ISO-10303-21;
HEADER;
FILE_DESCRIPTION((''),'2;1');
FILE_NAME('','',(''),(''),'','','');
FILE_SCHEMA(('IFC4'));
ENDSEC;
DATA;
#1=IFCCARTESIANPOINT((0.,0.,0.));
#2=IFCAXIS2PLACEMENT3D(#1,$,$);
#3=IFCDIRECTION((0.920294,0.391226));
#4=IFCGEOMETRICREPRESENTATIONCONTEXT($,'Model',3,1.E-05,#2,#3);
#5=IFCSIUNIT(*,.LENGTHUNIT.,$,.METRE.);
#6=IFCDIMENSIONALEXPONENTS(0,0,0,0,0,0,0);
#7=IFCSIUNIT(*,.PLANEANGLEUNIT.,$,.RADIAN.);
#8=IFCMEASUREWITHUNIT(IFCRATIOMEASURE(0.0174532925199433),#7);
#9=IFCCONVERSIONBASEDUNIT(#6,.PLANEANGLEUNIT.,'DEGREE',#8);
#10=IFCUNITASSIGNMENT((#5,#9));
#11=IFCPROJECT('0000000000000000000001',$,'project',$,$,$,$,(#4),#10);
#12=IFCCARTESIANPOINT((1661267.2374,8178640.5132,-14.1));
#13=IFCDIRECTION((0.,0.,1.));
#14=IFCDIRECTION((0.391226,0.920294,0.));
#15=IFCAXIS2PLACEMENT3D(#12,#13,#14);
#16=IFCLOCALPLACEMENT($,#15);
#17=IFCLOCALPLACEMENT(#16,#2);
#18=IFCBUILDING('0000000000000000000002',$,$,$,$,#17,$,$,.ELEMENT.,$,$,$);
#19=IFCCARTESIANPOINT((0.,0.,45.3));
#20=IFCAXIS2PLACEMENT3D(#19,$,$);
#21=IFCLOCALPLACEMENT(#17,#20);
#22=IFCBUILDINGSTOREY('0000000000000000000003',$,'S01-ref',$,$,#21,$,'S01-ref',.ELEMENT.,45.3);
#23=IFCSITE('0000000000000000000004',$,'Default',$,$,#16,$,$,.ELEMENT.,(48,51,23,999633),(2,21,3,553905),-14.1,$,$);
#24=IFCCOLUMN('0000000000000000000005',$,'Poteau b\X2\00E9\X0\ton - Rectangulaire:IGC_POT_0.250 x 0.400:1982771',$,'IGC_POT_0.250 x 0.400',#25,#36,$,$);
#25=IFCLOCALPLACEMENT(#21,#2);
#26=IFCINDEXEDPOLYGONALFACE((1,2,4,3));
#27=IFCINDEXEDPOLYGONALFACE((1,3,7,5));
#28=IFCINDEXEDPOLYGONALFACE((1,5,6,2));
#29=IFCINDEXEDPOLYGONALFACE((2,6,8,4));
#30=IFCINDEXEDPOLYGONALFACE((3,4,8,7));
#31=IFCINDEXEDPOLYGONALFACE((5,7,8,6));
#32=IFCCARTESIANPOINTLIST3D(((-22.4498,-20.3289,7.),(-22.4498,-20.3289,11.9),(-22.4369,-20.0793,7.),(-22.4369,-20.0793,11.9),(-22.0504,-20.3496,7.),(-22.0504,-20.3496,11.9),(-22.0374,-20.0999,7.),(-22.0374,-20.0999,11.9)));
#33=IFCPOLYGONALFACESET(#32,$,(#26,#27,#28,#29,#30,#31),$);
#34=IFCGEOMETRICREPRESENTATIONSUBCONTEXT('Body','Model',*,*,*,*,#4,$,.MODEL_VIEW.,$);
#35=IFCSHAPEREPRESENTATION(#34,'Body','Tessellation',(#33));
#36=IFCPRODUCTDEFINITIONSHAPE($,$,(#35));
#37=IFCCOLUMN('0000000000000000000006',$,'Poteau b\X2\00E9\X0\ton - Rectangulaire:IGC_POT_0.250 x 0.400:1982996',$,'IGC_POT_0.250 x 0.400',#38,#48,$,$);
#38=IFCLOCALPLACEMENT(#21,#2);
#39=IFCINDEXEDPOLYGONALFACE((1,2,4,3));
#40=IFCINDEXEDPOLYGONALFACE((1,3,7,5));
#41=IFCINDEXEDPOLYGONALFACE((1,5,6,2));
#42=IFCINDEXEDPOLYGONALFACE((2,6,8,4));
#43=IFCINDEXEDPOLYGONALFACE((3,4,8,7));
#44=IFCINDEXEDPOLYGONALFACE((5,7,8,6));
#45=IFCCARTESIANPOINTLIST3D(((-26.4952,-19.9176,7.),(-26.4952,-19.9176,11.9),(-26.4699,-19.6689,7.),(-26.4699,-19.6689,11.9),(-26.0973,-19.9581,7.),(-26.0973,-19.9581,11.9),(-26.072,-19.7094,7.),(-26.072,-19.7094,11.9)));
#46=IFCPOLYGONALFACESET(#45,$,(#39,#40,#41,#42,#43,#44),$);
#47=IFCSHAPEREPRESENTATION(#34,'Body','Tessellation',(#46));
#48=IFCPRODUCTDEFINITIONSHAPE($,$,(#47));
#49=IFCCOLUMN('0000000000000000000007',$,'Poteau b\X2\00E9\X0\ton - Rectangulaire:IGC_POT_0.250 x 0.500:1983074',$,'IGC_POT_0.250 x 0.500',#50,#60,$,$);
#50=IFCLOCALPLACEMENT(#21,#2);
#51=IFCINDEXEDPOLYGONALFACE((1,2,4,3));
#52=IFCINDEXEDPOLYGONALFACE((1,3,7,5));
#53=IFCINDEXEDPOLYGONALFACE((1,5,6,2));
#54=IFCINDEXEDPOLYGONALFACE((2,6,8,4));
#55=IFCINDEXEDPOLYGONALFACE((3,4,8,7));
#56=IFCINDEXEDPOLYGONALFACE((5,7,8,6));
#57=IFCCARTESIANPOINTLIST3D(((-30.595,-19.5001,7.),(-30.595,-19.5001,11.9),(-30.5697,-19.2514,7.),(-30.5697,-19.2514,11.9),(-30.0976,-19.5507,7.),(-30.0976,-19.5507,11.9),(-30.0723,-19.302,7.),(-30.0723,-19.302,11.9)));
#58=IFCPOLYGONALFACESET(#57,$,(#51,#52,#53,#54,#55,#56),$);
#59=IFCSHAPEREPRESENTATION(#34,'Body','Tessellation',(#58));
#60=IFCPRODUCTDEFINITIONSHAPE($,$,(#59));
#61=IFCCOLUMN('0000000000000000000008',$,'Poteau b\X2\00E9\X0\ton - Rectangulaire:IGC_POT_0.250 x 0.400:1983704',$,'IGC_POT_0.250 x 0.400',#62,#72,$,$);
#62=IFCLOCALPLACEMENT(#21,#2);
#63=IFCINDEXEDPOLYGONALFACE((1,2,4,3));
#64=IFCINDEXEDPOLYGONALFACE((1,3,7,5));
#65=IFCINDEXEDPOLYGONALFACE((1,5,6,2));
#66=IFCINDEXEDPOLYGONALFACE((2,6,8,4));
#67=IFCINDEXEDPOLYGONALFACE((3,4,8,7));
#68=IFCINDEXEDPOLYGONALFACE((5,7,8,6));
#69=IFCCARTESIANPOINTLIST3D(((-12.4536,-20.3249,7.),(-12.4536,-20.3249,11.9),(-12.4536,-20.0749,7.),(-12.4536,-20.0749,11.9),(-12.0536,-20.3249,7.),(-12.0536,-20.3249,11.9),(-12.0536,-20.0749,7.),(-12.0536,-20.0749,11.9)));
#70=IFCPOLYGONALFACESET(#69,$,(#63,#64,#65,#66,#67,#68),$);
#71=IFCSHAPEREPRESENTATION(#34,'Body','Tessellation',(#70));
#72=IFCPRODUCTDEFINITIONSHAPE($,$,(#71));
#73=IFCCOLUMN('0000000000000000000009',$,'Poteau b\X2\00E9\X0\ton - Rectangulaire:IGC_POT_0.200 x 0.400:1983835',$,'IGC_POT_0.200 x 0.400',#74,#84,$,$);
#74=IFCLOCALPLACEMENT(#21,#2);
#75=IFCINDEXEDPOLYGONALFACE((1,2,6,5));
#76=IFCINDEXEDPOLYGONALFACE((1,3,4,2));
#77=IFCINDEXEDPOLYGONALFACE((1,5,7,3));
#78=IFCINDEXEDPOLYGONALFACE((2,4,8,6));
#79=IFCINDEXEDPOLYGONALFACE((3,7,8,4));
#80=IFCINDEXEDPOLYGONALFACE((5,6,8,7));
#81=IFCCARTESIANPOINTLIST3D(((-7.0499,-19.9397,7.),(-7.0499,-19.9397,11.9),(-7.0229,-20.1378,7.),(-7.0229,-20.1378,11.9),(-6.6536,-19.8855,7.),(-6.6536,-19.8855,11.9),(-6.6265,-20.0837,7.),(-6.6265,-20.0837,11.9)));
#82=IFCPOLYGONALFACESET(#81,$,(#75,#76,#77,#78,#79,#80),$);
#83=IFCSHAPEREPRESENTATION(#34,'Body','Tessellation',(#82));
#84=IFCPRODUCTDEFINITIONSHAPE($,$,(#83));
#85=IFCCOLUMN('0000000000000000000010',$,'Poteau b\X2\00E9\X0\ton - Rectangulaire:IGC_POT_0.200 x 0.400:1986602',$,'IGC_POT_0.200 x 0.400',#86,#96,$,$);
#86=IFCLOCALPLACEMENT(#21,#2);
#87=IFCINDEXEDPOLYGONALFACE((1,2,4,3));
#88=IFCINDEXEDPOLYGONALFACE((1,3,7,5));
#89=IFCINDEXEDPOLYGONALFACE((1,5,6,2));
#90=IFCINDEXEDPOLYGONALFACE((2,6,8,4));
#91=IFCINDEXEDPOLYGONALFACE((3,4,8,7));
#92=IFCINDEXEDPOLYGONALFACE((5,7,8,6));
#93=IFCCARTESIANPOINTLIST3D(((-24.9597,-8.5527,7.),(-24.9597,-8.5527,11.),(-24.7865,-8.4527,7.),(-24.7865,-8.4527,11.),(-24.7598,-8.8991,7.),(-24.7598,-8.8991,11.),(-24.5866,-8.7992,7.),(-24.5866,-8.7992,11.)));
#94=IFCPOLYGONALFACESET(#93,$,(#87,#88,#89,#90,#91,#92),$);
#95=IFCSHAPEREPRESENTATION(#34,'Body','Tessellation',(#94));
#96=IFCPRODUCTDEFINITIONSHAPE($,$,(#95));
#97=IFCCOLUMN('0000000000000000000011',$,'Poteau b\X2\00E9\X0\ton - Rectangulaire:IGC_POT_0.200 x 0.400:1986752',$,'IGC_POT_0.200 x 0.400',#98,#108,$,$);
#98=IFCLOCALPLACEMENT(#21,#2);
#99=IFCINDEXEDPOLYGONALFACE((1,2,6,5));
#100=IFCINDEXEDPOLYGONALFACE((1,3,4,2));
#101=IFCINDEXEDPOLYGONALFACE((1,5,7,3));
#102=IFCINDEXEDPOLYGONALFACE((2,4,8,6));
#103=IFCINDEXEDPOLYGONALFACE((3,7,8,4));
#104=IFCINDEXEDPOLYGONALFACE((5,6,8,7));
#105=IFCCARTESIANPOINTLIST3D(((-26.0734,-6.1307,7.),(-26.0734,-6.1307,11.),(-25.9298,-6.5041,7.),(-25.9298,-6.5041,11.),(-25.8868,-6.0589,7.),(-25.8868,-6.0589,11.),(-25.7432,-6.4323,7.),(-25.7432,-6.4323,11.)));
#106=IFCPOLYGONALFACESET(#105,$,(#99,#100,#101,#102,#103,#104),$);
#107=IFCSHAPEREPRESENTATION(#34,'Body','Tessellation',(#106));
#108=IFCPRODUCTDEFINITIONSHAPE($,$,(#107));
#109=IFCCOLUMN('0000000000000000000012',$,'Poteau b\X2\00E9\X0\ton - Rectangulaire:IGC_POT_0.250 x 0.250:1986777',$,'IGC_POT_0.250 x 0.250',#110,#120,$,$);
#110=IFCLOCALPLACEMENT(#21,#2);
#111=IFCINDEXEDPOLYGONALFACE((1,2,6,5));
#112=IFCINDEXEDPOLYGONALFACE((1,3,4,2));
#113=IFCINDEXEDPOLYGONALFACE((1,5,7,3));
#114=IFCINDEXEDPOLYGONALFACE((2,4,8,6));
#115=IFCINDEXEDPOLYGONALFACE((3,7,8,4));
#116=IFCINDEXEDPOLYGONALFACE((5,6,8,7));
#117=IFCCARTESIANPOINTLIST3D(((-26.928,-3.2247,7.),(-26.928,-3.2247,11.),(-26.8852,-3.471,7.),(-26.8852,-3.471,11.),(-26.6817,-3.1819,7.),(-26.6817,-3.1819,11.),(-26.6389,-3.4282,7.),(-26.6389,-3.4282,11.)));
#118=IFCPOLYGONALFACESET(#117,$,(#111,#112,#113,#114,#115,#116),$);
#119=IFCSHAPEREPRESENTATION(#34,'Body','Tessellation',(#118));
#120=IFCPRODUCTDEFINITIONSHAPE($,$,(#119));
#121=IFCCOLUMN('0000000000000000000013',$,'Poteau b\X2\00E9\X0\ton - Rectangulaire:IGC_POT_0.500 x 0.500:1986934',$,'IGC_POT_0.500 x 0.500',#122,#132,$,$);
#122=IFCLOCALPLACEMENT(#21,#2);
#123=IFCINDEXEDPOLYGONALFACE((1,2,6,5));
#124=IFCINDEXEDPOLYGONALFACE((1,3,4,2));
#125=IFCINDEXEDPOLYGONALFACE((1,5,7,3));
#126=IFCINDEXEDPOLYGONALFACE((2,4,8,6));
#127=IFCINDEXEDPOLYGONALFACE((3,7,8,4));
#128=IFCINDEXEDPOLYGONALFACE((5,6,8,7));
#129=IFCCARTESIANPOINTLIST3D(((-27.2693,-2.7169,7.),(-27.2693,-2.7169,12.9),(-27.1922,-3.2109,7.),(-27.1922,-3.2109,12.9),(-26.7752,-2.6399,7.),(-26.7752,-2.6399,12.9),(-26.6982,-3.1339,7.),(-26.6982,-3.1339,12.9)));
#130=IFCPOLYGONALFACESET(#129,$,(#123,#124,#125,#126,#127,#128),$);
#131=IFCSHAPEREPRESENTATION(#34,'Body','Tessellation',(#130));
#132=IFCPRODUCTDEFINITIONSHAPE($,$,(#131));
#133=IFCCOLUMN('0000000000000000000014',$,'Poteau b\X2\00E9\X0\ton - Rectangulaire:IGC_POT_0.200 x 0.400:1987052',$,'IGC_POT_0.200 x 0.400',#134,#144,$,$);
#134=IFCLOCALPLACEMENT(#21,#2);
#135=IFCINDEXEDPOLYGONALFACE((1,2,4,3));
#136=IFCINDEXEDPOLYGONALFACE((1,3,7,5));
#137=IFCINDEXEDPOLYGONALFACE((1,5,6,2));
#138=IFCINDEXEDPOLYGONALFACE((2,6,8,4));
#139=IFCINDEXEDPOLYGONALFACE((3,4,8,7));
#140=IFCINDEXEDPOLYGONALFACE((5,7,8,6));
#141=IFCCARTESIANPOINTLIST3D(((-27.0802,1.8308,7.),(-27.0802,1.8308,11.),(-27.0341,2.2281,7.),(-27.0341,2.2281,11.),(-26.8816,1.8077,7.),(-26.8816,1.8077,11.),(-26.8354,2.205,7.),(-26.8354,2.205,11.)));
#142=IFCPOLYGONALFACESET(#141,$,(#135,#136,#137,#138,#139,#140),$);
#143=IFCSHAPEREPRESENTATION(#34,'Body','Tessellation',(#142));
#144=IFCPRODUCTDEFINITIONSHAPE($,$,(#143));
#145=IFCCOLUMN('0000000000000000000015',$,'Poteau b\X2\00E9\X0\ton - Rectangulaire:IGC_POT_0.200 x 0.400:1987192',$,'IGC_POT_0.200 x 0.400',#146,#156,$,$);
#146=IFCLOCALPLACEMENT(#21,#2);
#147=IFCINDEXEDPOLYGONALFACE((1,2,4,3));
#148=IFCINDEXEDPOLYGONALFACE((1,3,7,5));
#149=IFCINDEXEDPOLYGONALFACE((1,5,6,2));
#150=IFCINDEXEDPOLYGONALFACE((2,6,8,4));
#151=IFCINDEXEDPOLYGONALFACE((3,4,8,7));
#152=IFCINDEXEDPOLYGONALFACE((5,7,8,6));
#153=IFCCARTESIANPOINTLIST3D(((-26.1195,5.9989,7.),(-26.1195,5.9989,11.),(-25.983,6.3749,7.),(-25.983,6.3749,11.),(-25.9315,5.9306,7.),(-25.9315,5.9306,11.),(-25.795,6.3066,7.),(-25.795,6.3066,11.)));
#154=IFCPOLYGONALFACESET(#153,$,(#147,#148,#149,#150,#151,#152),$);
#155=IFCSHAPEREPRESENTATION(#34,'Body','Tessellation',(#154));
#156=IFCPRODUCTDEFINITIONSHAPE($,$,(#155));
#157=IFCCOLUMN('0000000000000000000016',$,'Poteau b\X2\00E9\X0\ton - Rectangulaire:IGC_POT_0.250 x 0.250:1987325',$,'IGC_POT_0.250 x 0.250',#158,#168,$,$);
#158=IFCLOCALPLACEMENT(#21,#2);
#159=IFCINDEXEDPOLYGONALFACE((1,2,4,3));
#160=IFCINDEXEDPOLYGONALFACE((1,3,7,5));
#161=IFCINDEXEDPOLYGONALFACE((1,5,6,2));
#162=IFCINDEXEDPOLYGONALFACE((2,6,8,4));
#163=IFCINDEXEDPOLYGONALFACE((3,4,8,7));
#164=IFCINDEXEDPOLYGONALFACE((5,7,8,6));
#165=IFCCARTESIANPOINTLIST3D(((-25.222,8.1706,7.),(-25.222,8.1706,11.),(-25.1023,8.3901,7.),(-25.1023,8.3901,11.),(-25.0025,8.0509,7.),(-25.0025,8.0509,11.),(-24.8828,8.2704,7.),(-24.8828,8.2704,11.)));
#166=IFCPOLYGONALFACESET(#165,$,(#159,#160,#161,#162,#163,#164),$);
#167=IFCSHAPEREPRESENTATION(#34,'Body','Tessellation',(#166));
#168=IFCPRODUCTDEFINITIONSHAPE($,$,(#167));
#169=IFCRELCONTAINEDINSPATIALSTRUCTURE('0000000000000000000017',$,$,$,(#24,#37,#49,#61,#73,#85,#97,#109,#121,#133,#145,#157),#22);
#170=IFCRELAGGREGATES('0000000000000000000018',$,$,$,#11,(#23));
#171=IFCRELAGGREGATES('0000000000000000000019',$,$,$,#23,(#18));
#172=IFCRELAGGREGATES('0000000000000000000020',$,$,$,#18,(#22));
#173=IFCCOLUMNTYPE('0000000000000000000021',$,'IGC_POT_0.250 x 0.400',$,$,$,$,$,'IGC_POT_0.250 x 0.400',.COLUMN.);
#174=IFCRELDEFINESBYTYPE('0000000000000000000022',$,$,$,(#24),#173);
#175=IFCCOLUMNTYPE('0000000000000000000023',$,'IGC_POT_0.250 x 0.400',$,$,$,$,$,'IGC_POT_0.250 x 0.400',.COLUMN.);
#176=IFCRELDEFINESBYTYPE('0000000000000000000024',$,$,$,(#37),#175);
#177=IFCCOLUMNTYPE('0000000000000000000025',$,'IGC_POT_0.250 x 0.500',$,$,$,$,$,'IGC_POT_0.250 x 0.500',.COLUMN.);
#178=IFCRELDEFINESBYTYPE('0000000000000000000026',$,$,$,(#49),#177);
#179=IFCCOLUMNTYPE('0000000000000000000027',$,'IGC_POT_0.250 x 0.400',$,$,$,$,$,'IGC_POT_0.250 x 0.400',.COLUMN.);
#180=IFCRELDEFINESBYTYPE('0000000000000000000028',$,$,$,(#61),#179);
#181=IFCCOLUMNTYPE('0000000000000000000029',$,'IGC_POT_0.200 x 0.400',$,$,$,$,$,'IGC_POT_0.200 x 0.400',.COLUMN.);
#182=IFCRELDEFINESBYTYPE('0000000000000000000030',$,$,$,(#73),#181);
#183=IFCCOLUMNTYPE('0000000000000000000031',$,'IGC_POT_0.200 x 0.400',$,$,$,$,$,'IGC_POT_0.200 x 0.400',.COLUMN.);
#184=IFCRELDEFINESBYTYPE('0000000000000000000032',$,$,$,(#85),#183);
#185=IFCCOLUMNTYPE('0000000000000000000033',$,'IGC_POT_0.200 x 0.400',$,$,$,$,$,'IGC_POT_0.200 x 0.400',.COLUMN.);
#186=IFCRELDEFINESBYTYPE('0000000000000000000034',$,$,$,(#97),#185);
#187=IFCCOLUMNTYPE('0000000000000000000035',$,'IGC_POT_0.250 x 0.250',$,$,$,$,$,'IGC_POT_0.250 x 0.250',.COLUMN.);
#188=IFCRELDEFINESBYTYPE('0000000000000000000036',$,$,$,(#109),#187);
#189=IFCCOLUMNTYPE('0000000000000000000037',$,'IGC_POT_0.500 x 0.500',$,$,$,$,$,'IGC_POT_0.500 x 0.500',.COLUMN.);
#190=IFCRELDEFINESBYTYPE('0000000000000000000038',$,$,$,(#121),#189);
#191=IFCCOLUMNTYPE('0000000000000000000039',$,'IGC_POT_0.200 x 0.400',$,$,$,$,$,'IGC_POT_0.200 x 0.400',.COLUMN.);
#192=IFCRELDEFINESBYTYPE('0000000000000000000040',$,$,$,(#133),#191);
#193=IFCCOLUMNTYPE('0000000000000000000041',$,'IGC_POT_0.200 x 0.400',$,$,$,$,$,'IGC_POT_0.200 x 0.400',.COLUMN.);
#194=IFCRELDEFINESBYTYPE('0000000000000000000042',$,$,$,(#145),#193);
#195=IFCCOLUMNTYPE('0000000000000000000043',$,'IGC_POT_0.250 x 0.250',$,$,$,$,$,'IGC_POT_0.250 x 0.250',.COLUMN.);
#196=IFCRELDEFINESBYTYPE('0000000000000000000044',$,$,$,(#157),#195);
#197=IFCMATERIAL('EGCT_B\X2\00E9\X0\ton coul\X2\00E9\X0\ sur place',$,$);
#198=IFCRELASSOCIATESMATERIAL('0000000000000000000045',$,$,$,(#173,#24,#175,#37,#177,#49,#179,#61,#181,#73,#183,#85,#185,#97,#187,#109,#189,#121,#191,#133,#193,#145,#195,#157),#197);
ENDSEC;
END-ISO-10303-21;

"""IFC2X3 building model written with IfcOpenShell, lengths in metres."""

from ifc_helpers import new_model, entity, si_unit, converted_unit, direction, frame, frame_2d, origin, origin_2d_with_axis, place, context, subcontext, project, spatial, rectangle, extrude, source, transform, mapped, material, type_object, type_shapes, element, save


model = new_model("IFC2X3")

# Units and contexts
model_context = context("Model", 3, precision=1e-05, world=origin(), true_north=direction((0.920294, 0.391226)))
body_context = subcontext(model_context, "Body", "Model", "MODEL_VIEW")
ifc_project = project(units=[si_unit("LENGTHUNIT", "METRE"), converted_unit("PLANEANGLEUNIT", "DEGREE", entity("IfcRatioMeasure", 0.0174532925199433), si_unit("PLANEANGLEUNIT", "RADIAN"), dimensions=[0, 0, 0, 0, 0, 0, 0])], contexts=[model_context])

# Site, building, storey
site_placement = place(None, frame((1661267.2374, 8178640.5132, -14.1), z_axis=(0.0, 0.0, 1.0), x_axis=(0.391226, 0.920294, 0.0)))
site = spatial("IfcSite", under=ifc_project, at=site_placement, Name="Default", CompositionType="ELEMENT", RefLatitude=(48, 51, 23, 999633), RefLongitude=(2, 21, 3, 553905), RefElevation=-14.1)
building_placement = place(site_placement, origin())
building = spatial("IfcBuilding", under=site, at=building_placement, CompositionType="ELEMENT")
storey_placement = place(building_placement, frame((0.0, 0.0, 45.3)))
storey = spatial("IfcBuildingStorey", under=building, at=storey_placement, Name="S01-ref", LongName="S01-ref", CompositionType="ELEMENT", Elevation=45.3)

# Columns
ifc_material = material(Name="EGCT_Béton coulé sur place")
column_type_1 = type_object("IfcColumnType", Name="IGC_POT_0.250 x 0.400", ElementType="IGC_POT_0.250 x 0.400", PredefinedType="COLUMN", material=ifc_material)
shared_shape_1 = source(origin(), body_context, "Body", "SweptSolid", [
    extrude(rectangle(XDim=0.25, YDim=0.4, at=frame_2d((0.0, 0.0), x_axis=(1.0, 0.0))), frame((-22.2436, -20.2144, 52.3), z_axis=(0.0, 0.0, 1.0), x_axis=(0.051722, 0.998662, 0.0)), (0.0, 0.0, 1.0), 4.9),
])
type_shapes(column_type_1, [shared_shape_1])
column_1_placement = place(storey_placement, frame((0.0, 0.0, -45.3)))
element("IfcColumn", 1, at=column_1_placement, inside=storey, type_object=column_type_1, material=ifc_material, Name="Poteau béton - Rectangulaire:IGC_POT_0.250 x 0.400:1982771", ObjectType="IGC_POT_0.250 x 0.400", context=body_context, shape_type="MappedRepresentation", body=[
    mapped(shared_shape_1, transform((0.0, 0.0, 0.0), scale=1.0)),
])
column_type_2 = type_object("IfcColumnType", Name="IGC_POT_0.250 x 0.400", ElementType="IGC_POT_0.250 x 0.400", PredefinedType="COLUMN", material=ifc_material)
shared_shape_2 = source(origin(), body_context, "Body", "SweptSolid", [
    extrude(rectangle(XDim=0.25, YDim=0.4, at=frame_2d((0.0, 0.0), x_axis=(1.0, 0.0))), frame((-26.2836, -19.8135, 52.3), z_axis=(0.0, 0.0, 1.0), x_axis=(0.101222, 0.994864, 0.0)), (0.0, 0.0, 1.0), 4.9),
])
type_shapes(column_type_2, [shared_shape_2])
column_2_placement = place(storey_placement, frame((0.0, 0.0, -45.3)))
element("IfcColumn", 2, at=column_2_placement, inside=storey, type_object=column_type_2, material=ifc_material, Name="Poteau béton - Rectangulaire:IGC_POT_0.250 x 0.400:1982996", ObjectType="IGC_POT_0.250 x 0.400", context=body_context, shape_type="MappedRepresentation", body=[
    mapped(shared_shape_2, transform((0.0, 0.0, 0.0), scale=1.0)),
])
column_type_3 = type_object("IfcColumnType", Name="IGC_POT_0.250 x 0.500", ElementType="IGC_POT_0.250 x 0.500", PredefinedType="COLUMN", material=ifc_material)
shared_shape_3 = source(origin(), body_context, "Body", "SweptSolid", [
    extrude(rectangle(XDim=0.25, YDim=0.5, at=frame_2d((0.0, 0.0), x_axis=(1.0, 0.0))), frame((-30.3336, -19.4011, 52.3), z_axis=(0.0, 0.0, 1.0), x_axis=(0.101222, 0.994864, 0.0)), (0.0, 0.0, 1.0), 4.9),
])
type_shapes(column_type_3, [shared_shape_3])
column_3_placement = place(storey_placement, frame((0.0, 0.0, -45.3)))
element("IfcColumn", 3, at=column_3_placement, inside=storey, type_object=column_type_3, material=ifc_material, Name="Poteau béton - Rectangulaire:IGC_POT_0.250 x 0.500:1983074", ObjectType="IGC_POT_0.250 x 0.500", context=body_context, shape_type="MappedRepresentation", body=[
    mapped(shared_shape_3, transform((0.0, 0.0, 0.0), scale=1.0)),
])
column_type_4 = type_object("IfcColumnType", Name="IGC_POT_0.250 x 0.400", ElementType="IGC_POT_0.250 x 0.400", PredefinedType="COLUMN", material=ifc_material)
shared_shape_4 = source(origin(), body_context, "Body", "SweptSolid", [
    extrude(rectangle(XDim=0.25, YDim=0.4, at=frame_2d((0.0, 0.0), x_axis=(1.0, 0.0))), frame((-12.2536, -20.1999, 52.3), z_axis=(0.0, 0.0, 1.0), x_axis=(0.000003, 1.0, 0.0)), (0.0, 0.0, 1.0), 4.9),
])
type_shapes(column_type_4, [shared_shape_4])
column_4_placement = place(storey_placement, frame((0.0, 0.0, -45.3)))
element("IfcColumn", 4, at=column_4_placement, inside=storey, type_object=column_type_4, material=ifc_material, Name="Poteau béton - Rectangulaire:IGC_POT_0.250 x 0.400:1983704", ObjectType="IGC_POT_0.250 x 0.400", context=body_context, shape_type="MappedRepresentation", body=[
    mapped(shared_shape_4, transform((0.0, 0.0, 0.0), scale=1.0)),
])
column_type_5 = type_object("IfcColumnType", Name="IGC_POT_0.200 x 0.400", ElementType="IGC_POT_0.200 x 0.400", PredefinedType="COLUMN", material=ifc_material)
shared_shape_5 = source(origin(), body_context, "Body", "SweptSolid", [
    extrude(rectangle(XDim=0.2, YDim=0.4, at=frame_2d((0.0, 0.0), x_axis=(1.0, 0.0))), frame((-6.8382, -20.0117, 52.3), z_axis=(0.0, 0.0, 1.0), x_axis=(-0.135411, 0.99079, 0.0)), (0.0, 0.0, 1.0), 4.9),
])
type_shapes(column_type_5, [shared_shape_5])
column_5_placement = place(storey_placement, frame((0.0, 0.0, -45.3)))
element("IfcColumn", 5, at=column_5_placement, inside=storey, type_object=column_type_5, material=ifc_material, Name="Poteau béton - Rectangulaire:IGC_POT_0.200 x 0.400:1983835", ObjectType="IGC_POT_0.200 x 0.400", context=body_context, shape_type="MappedRepresentation", body=[
    mapped(shared_shape_5, transform((0.0, 0.0, 0.0), scale=1.0)),
])
column_type_6 = type_object("IfcColumnType", Name="IGC_POT_0.200 x 0.400", ElementType="IGC_POT_0.200 x 0.400", PredefinedType="COLUMN", material=ifc_material)
shared_shape_6 = source(origin(), body_context, "Body", "SweptSolid", [
    extrude(rectangle(XDim=0.4, YDim=0.2, at=frame_2d((0.0, 0.0), x_axis=(1.0, 0.0))), frame((-24.7732, -8.6759, 52.3), z_axis=(0.0, 0.0, 1.0), x_axis=(-0.499774, 0.866156, 0.0)), (0.0, 0.0, 1.0), 4.0),
])
type_shapes(column_type_6, [shared_shape_6])
column_6_placement = place(storey_placement, frame((0.0, 0.0, -45.3)))
element("IfcColumn", 6, at=column_6_placement, inside=storey, type_object=column_type_6, material=ifc_material, Name="Poteau béton - Rectangulaire:IGC_POT_0.200 x 0.400:1986602", ObjectType="IGC_POT_0.200 x 0.400", context=body_context, shape_type="MappedRepresentation", body=[
    mapped(shared_shape_6, transform((0.0, 0.0, 0.0), scale=1.0)),
])
column_type_7 = type_object("IfcColumnType", Name="IGC_POT_0.200 x 0.400", ElementType="IGC_POT_0.200 x 0.400", PredefinedType="COLUMN", material=ifc_material)
shared_shape_7 = source(origin(), body_context, "Body", "SweptSolid", [
    extrude(rectangle(XDim=0.4, YDim=0.2, at=origin_2d_with_axis()), frame((-25.9083, -6.2815, 52.3), z_axis=(0.0, 0.0, 1.0), x_axis=(-0.358954, 0.933355, 0.0)), (0.0, 0.0, 1.0), 4.0),
])
type_shapes(column_type_7, [shared_shape_7])
column_7_placement = place(storey_placement, frame((0.0, 0.0, -45.3)))
element("IfcColumn", 7, at=column_7_placement, inside=storey, type_object=column_type_7, material=ifc_material, Name="Poteau béton - Rectangulaire:IGC_POT_0.200 x 0.400:1986752", ObjectType="IGC_POT_0.200 x 0.400", context=body_context, shape_type="MappedRepresentation", body=[
    mapped(shared_shape_7, transform((0.0, 0.0, 0.0), scale=1.0)),
])
column_type_8 = type_object("IfcColumnType", Name="IGC_POT_0.250 x 0.250", ElementType="IGC_POT_0.250 x 0.250", PredefinedType="COLUMN", material=ifc_material)
shared_shape_8 = source(origin(), body_context, "Body", "SweptSolid", [
    extrude(rectangle(XDim=0.25, YDim=0.25, at=frame_2d((0.0, 0.0), x_axis=(1.0, 0.0))), frame((-26.7835, -3.3264, 52.3), z_axis=(0.0, 0.0, 1.0), x_axis=(-0.1713, 0.985219, 0.0)), (0.0, 0.0, 1.0), 4.0),
])
type_shapes(column_type_8, [shared_shape_8])
column_8_placement = place(storey_placement, frame((0.0, 0.0, -45.3)))
element("IfcColumn", 8, at=column_8_placement, inside=storey, type_object=column_type_8, material=ifc_material, Name="Poteau béton - Rectangulaire:IGC_POT_0.250 x 0.250:1986777", ObjectType="IGC_POT_0.250 x 0.250", context=body_context, shape_type="MappedRepresentation", body=[
    mapped(shared_shape_8, transform((0.0, 0.0, 0.0), scale=1.0)),
])
column_type_9 = type_object("IfcColumnType", Name="IGC_POT_0.500 x 0.500", ElementType="IGC_POT_0.500 x 0.500", PredefinedType="COLUMN", material=ifc_material)
shared_shape_9 = source(origin(), body_context, "Body", "SweptSolid", [
    extrude(rectangle(XDim=0.5, YDim=0.5, at=frame_2d((0.0, 0.0), x_axis=(1.0, 0.0))), frame((-26.9837, -2.9254, 52.3), z_axis=(0.0, 0.0, 1.0), x_axis=(-0.15408, 0.988058, 0.0)), (0.0, 0.0, 1.0), 5.9),
])
type_shapes(column_type_9, [shared_shape_9])
column_9_placement = place(storey_placement, frame((0.0, 0.0, -45.3)))
element("IfcColumn", 9, at=column_9_placement, inside=storey, type_object=column_type_9, material=ifc_material, Name="Poteau béton - Rectangulaire:IGC_POT_0.500 x 0.500:1986934", ObjectType="IGC_POT_0.500 x 0.500", context=body_context, shape_type="MappedRepresentation", body=[
    mapped(shared_shape_9, transform((0.0, 0.0, 0.0), scale=1.0)),
])
column_type_10 = type_object("IfcColumnType", Name="IGC_POT_0.200 x 0.400", ElementType="IGC_POT_0.200 x 0.400", PredefinedType="COLUMN", material=ifc_material)
shared_shape_10 = source(origin(), body_context, "Body", "SweptSolid", [
    extrude(rectangle(XDim=0.2, YDim=0.4, at=origin_2d_with_axis()), frame((-26.9578, 2.0179, 52.3), z_axis=(0.0, 0.0, 1.0), x_axis=(-0.99333, 0.11531, 0.0)), (0.0, 0.0, 1.0), 4.0),
])
type_shapes(column_type_10, [shared_shape_10])
column_10_placement = place(storey_placement, frame((0.0, 0.0, -45.3)))
element("IfcColumn", 10, at=column_10_placement, inside=storey, type_object=column_type_10, material=ifc_material, Name="Poteau béton - Rectangulaire:IGC_POT_0.200 x 0.400:1987052", ObjectType="IGC_POT_0.200 x 0.400", context=body_context, shape_type="MappedRepresentation", body=[
    mapped(shared_shape_10, transform((0.0, 0.0, 0.0), scale=1.0)),
])
column_type_11 = type_object("IfcColumnType", Name="IGC_POT_0.200 x 0.400", ElementType="IGC_POT_0.200 x 0.400", PredefinedType="COLUMN", material=ifc_material)
shared_shape_11 = source(origin(), body_context, "Body", "SweptSolid", [
    extrude(rectangle(XDim=0.4, YDim=0.2, at=origin_2d_with_axis()), frame((-25.9573, 6.1528, 52.3), z_axis=(0.0, 0.0, 1.0), x_axis=(0.341211, 0.939987, 0.0)), (0.0, 0.0, 1.0), 4.0),
])
type_shapes(column_type_11, [shared_shape_11])
column_11_placement = place(storey_placement, frame((0.0, 0.0, -45.3)))
element("IfcColumn", 11, at=column_11_placement, inside=storey, type_object=column_type_11, material=ifc_material, Name="Poteau béton - Rectangulaire:IGC_POT_0.200 x 0.400:1987192", ObjectType="IGC_POT_0.200 x 0.400", context=body_context, shape_type="MappedRepresentation", body=[
    mapped(shared_shape_11, transform((0.0, 0.0, 0.0), scale=1.0)),
])
column_type_12 = type_object("IfcColumnType", Name="IGC_POT_0.250 x 0.250", ElementType="IGC_POT_0.250 x 0.250", PredefinedType="COLUMN", material=ifc_material)
shared_shape_12 = source(origin(), body_context, "Body", "SweptSolid", [
    extrude(rectangle(XDim=0.25, YDim=0.25, at=origin_2d_with_axis()), frame((-25.0524, 8.2205, 52.3), z_axis=(0.0, 0.0, 1.0), x_axis=(0.478796, 0.877926, 0.0)), (0.0, 0.0, 1.0), 4.0),
])
type_shapes(column_type_12, [shared_shape_12])
column_12_placement = place(storey_placement, frame((0.0, 0.0, -45.3)))
element("IfcColumn", 12, at=column_12_placement, inside=storey, type_object=column_type_12, material=ifc_material, Name="Poteau béton - Rectangulaire:IGC_POT_0.250 x 0.250:1987325", ObjectType="IGC_POT_0.250 x 0.250", context=body_context, shape_type="MappedRepresentation", body=[
    mapped(shared_shape_12, transform((0.0, 0.0, 0.0), scale=1.0)),
])

save(model, "model.ifc")
